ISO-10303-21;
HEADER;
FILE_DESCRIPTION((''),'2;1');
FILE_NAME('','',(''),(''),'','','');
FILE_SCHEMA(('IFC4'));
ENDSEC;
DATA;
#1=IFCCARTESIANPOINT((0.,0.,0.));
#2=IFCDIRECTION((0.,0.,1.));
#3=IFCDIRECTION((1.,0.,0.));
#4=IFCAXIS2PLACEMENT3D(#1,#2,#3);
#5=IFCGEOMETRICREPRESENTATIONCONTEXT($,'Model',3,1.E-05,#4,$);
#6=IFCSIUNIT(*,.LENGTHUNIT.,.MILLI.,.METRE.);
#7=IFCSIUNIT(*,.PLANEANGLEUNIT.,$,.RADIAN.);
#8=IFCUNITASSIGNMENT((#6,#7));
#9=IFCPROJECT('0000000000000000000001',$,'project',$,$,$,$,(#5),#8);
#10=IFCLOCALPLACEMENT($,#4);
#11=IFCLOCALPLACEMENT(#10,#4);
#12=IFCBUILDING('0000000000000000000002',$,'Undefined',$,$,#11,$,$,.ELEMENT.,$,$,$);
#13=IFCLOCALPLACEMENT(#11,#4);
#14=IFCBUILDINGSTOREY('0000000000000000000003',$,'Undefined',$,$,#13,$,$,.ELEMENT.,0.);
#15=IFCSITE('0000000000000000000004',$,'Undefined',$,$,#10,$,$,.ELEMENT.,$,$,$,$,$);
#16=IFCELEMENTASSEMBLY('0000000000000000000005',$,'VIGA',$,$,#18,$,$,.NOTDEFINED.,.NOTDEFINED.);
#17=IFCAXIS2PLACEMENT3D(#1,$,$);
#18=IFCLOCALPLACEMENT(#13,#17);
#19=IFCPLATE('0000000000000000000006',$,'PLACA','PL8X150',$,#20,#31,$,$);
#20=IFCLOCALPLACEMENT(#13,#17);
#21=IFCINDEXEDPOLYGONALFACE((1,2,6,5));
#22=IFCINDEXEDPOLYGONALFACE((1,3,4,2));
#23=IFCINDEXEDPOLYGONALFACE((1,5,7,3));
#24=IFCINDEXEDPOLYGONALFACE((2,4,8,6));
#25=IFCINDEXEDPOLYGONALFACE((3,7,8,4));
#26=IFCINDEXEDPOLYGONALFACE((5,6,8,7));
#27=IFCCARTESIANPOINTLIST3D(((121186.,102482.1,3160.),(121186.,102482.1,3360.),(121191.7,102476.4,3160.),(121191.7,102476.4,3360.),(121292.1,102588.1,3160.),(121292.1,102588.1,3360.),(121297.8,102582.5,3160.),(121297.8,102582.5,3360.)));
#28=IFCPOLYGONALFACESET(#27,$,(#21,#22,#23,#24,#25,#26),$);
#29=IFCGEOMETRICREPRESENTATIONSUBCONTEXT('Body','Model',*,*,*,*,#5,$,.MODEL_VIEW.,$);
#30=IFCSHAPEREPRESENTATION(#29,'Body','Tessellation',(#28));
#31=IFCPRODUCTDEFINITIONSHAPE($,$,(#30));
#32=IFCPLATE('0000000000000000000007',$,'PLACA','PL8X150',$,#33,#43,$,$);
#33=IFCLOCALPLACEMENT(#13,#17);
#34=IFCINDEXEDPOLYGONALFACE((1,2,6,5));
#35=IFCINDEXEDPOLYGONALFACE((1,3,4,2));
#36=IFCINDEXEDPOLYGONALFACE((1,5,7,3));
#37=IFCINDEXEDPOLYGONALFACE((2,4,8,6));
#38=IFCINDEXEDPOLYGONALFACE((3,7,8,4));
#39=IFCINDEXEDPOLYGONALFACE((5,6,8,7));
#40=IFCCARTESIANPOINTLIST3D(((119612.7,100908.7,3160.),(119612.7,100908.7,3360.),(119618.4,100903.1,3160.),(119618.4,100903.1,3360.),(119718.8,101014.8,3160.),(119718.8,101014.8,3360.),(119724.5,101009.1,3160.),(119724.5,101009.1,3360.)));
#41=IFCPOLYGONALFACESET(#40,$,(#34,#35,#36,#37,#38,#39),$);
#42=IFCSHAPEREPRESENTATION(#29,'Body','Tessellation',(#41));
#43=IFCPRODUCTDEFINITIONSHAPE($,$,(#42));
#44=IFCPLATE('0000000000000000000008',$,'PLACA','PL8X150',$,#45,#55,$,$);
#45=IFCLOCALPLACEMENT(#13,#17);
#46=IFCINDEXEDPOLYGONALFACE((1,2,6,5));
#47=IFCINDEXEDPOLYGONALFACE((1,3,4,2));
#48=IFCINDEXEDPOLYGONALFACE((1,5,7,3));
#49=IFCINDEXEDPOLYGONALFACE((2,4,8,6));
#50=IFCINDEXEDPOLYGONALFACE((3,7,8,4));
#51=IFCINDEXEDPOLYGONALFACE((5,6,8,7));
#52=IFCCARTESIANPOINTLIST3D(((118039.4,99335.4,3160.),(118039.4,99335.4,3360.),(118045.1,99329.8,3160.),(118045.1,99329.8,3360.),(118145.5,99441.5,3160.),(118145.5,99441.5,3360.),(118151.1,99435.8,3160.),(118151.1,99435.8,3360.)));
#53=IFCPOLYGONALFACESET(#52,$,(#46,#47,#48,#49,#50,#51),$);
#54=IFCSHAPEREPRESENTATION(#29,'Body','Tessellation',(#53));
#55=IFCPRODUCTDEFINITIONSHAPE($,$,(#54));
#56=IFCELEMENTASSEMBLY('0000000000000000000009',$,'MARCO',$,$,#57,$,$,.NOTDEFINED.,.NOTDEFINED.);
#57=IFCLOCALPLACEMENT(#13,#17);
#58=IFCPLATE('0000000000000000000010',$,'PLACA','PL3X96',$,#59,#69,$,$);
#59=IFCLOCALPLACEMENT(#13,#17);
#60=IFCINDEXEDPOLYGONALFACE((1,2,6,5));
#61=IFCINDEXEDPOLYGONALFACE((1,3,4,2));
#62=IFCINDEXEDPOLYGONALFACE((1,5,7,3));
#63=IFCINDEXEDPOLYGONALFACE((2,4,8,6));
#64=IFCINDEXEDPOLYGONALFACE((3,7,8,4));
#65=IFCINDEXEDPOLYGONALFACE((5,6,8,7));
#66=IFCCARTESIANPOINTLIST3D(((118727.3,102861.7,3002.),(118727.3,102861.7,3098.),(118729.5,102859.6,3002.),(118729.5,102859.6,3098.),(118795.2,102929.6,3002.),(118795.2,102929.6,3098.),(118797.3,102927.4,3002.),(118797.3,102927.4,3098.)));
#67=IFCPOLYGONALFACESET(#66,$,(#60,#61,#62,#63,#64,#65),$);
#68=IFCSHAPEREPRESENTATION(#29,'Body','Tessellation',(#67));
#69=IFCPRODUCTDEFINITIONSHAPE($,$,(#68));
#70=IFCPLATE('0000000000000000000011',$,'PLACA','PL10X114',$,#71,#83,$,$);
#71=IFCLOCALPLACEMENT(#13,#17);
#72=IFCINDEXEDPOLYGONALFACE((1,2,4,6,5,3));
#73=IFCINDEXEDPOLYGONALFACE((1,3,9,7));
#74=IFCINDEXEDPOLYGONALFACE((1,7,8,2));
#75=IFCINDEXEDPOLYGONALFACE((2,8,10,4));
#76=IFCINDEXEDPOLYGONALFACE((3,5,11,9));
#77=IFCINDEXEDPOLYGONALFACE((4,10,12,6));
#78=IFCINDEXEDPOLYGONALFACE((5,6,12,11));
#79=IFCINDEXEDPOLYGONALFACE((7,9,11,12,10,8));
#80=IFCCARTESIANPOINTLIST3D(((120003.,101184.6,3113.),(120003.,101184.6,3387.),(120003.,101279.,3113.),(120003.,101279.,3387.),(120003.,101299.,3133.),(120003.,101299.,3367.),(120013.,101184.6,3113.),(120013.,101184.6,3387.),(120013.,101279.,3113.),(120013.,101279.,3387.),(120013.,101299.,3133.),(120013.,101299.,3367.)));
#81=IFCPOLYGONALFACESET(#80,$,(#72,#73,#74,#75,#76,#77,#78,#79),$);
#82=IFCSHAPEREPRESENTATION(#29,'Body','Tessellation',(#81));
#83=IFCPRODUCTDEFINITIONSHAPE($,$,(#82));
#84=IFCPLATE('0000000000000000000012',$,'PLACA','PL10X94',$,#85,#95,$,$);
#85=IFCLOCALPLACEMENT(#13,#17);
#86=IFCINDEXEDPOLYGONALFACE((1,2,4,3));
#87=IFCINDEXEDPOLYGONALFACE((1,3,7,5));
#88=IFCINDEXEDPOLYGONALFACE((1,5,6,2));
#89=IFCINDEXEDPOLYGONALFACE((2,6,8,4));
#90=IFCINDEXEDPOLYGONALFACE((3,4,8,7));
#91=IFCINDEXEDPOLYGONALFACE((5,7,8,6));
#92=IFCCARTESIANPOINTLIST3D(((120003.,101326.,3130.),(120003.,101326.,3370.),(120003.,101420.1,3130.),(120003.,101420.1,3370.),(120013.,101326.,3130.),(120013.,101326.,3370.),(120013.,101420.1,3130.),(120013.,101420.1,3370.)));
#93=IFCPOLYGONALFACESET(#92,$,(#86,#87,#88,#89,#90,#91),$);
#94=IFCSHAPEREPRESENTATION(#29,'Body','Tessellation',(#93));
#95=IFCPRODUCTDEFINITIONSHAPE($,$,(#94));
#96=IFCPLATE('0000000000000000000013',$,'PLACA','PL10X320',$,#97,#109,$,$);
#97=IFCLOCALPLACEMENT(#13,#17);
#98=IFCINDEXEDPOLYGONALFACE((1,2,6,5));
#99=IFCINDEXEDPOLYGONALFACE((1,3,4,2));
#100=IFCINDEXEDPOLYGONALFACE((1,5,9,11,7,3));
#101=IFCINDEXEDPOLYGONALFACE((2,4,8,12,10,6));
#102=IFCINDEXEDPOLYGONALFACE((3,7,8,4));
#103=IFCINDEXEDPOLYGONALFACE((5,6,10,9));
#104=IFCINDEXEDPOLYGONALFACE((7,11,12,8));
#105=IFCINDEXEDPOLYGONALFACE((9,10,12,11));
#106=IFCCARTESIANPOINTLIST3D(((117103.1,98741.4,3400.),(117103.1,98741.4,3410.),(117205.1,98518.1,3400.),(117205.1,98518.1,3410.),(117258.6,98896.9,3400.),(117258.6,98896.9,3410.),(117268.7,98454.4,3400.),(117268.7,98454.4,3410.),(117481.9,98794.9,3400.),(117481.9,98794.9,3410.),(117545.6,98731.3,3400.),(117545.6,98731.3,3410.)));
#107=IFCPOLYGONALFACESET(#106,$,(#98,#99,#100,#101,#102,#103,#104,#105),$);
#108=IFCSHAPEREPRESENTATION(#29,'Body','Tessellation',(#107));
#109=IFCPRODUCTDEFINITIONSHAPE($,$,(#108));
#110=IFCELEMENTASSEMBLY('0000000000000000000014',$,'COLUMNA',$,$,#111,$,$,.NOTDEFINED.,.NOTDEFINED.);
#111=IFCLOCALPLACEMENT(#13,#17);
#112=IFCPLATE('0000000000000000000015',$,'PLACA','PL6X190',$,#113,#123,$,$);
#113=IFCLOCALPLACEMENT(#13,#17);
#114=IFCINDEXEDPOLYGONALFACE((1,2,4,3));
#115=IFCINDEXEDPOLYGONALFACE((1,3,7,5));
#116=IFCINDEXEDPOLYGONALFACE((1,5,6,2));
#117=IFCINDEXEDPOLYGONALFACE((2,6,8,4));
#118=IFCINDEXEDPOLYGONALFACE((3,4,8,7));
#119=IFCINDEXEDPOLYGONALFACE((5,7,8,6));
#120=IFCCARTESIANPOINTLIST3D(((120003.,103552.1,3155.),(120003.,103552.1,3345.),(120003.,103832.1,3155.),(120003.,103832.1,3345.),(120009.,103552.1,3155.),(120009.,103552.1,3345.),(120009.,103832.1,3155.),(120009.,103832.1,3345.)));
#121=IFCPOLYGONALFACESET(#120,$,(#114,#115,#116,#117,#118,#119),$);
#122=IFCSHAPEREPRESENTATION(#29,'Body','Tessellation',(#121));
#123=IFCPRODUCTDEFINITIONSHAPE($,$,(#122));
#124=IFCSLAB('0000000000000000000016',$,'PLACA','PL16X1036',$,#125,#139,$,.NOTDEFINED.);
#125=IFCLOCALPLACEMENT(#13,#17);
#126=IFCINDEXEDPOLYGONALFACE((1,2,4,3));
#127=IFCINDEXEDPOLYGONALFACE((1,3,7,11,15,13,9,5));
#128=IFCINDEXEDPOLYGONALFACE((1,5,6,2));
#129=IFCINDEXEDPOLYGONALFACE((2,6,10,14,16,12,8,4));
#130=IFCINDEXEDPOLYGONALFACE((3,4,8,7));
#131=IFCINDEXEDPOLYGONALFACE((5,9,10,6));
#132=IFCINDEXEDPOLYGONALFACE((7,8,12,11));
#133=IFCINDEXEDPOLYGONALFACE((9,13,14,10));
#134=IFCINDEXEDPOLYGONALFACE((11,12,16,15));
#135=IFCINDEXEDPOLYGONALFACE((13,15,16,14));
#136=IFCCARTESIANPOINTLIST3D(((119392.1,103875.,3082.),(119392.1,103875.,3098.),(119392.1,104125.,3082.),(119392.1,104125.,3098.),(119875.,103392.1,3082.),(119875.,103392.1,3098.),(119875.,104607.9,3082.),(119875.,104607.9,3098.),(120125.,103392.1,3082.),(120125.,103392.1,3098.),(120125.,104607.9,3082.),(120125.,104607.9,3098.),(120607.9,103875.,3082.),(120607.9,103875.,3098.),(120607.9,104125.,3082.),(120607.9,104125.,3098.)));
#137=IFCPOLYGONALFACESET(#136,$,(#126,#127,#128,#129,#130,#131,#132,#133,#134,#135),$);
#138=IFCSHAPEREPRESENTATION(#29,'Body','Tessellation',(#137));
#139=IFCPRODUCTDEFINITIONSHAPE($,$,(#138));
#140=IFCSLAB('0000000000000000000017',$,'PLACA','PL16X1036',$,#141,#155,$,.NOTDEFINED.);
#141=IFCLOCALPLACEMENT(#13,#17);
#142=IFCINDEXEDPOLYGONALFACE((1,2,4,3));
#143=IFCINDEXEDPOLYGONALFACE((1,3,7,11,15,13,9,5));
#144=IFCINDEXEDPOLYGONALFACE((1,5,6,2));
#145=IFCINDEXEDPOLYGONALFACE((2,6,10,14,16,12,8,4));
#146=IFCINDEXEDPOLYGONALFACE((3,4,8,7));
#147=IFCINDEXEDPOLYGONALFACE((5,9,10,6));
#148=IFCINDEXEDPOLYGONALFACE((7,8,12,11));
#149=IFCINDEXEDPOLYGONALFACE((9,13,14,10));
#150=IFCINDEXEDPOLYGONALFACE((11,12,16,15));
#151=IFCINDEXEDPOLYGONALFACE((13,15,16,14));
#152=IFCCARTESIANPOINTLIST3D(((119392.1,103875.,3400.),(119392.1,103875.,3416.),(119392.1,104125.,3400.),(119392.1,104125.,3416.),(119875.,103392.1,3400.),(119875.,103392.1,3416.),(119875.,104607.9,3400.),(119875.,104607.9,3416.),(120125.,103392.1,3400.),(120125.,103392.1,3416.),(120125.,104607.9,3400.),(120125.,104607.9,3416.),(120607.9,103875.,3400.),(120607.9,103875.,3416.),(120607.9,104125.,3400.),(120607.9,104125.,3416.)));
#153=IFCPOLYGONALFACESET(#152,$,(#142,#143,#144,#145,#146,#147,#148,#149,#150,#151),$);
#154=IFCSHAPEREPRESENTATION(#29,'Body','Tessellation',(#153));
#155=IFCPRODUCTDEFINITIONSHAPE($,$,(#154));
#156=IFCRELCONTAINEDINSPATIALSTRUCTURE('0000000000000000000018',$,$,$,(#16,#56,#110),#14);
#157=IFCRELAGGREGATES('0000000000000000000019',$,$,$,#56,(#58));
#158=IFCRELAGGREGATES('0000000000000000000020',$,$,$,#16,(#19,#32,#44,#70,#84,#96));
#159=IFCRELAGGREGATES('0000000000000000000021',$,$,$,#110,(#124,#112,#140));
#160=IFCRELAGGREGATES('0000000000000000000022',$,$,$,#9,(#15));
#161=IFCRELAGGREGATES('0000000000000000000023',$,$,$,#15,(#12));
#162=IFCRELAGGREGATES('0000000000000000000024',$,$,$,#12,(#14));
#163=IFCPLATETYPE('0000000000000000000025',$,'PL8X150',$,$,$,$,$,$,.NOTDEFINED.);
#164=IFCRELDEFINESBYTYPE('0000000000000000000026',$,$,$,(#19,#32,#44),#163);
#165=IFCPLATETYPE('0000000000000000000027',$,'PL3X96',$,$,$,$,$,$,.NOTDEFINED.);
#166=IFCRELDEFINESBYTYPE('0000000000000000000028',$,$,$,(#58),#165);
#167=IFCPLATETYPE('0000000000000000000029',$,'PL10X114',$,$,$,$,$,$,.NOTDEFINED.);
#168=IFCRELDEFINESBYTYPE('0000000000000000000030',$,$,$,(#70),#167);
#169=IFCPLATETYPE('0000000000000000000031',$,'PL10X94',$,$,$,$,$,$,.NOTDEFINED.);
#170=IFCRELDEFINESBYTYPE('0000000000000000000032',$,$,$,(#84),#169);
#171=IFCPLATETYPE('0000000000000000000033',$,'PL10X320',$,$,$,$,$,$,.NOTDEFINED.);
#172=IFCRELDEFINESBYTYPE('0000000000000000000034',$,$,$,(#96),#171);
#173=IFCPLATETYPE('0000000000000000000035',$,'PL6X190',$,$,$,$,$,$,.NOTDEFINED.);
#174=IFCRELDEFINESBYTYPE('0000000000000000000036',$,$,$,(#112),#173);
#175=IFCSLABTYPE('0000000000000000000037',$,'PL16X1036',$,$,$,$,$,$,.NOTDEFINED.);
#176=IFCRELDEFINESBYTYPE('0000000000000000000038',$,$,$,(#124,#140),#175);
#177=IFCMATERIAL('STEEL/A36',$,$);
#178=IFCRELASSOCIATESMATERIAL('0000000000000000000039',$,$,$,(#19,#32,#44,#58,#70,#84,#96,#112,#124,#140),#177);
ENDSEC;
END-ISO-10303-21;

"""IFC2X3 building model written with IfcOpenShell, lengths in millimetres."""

from ifc_helpers import new_model, si_unit, frame, origin_with_axes, place, context, subcontext, project, spatial, polyline, outline, extrude, material, type_object, element, aggregate, save


model = new_model("IFC2X3")

# Units and contexts
model_context = context("Model", 3, precision=1e-05, world=origin_with_axes())
body_context = subcontext(model_context, "Body", "Model", "MODEL_VIEW")
ifc_project = project(units=[si_unit("LENGTHUNIT", "METRE", prefix="MILLI"), si_unit("PLANEANGLEUNIT", "RADIAN")], contexts=[model_context])

# Site, building, storey
site_placement = place(None, origin_with_axes())
site = spatial("IfcSite", under=ifc_project, at=site_placement, Name="Undefined", CompositionType="ELEMENT")
building_placement = place(site_placement, origin_with_axes())
building = spatial("IfcBuilding", under=site, at=building_placement, Name="Undefined", CompositionType="ELEMENT")
storey_placement = place(building_placement, origin_with_axes())
storey = spatial("IfcBuildingStorey", under=building, at=storey_placement, Name="Undefined", CompositionType="ELEMENT", Elevation=0.0)

# Shared definitions
ifc_material_1 = material(Name="STEEL/A36")

# Element assembly
assembly_1_placement = place(storey_placement, origin_with_axes())
assembly_1 = element("IfcElementAssembly", 1, at=assembly_1_placement, inside=storey, Name="VIGA", AssemblyPlace="NOTDEFINED", PredefinedType="NOTDEFINED")

# Plates
plate_type_1 = type_object("IfcPlateType", Name="PL8X150", PredefinedType="NOTDEFINED")
plate_1_placement = place(assembly_1_placement, frame((121188.9, 102479.2, 3360.0), z_axis=(-0.707107, 0.707106, 0.0), x_axis=(0.707106, 0.707107, 0.0)))
plate_1 = element("IfcPlate", 2, at=plate_1_placement, type_object=plate_type_1, material=ifc_material_1, Name="PLACA", Description="PL8X150", context=body_context, shape_type="SweptSolid", body=[
    extrude(outline(polyline([(0.0, 0.0), (150.0, 0.0), (150.0, 200.0), (0.0, 200.0), (0.0, 0.0)])), frame((0.0, 0.0, -4.0), z_axis=(0.0, 0.0, 1.0), x_axis=(1.0, 0.0, 0.0)), (0.0, 0.0, 1.0), 8.0),
])
plate_2_placement = place(assembly_1_placement, frame((119615.6, 100905.9, 3360.0), z_axis=(-0.707107, 0.707106, 0.0), x_axis=(0.707106, 0.707107, 0.0)))
plate_2 = element("IfcPlate", 3, at=plate_2_placement, type_object=plate_type_1, material=ifc_material_1, Name="PLACA", Description="PL8X150", context=body_context, shape_type="SweptSolid", body=[
    extrude(outline(polyline([(0.0, 0.0), (150.0, 0.0), (150.0, 200.0), (0.0, 200.0), (0.0, 0.0)])), frame((0.0, 0.0, -4.0), z_axis=(0.0, 0.0, 1.0), x_axis=(1.0, 0.0, 0.0)), (0.0, 0.0, 1.0), 8.0),
])
plate_3_placement = place(assembly_1_placement, frame((118042.2, 99332.6, 3360.0), z_axis=(-0.707107, 0.707106, 0.0), x_axis=(0.707106, 0.707107, 0.0)))
plate_3 = element("IfcPlate", 4, at=plate_3_placement, type_object=plate_type_1, material=ifc_material_1, Name="PLACA", Description="PL8X150", context=body_context, shape_type="SweptSolid", body=[
    extrude(outline(polyline([(0.0, 0.0), (150.0, 0.0), (150.0, 200.0), (0.0, 200.0), (0.0, 0.0)])), frame((0.0, 0.0, -4.0), z_axis=(0.0, 0.0, 1.0), x_axis=(1.0, 0.0, 0.0)), (0.0, 0.0, 1.0), 8.0),
])

# Element assembly, plate
assembly_2_placement = place(storey_placement, origin_with_axes())
assembly_2 = element("IfcElementAssembly", 5, at=assembly_2_placement, inside=storey, Name="MARCO", AssemblyPlace="NOTDEFINED", PredefinedType="NOTDEFINED")
plate_type_2 = type_object("IfcPlateType", Name="PL3X96", PredefinedType="NOTDEFINED")
plate_4_placement = place(assembly_2_placement, frame((118728.4, 102860.6, 3098.0), z_axis=(-0.707107, 0.707107, 0.0), x_axis=(0.707107, 0.707107, 0.0)))
plate_4 = element("IfcPlate", 6, at=plate_4_placement, type_object=plate_type_2, material=ifc_material_1, Name="PLACA", Description="PL3X96", context=body_context, shape_type="SweptSolid", body=[
    extrude(outline(polyline([(0.0, 0.0), (96.0, 0.0), (96.0, 96.0), (0.0, 96.0), (0.0, 0.0)])), frame((0.0, 0.0, -1.5), z_axis=(0.0, 0.0, 1.0), x_axis=(1.0, 0.0, 0.0)), (0.0, 0.0, 1.0), 3.0),
])
aggregate(assembly_2, [plate_4])

# Plates
plate_type_3 = type_object("IfcPlateType", Name="PL10X114", PredefinedType="NOTDEFINED")
plate_5_placement = place(assembly_1_placement, frame((120008.0, 101299.0, 3113.0), z_axis=(-1.0, 0.0, 0.0), x_axis=(0.0, -1.0, 0.0)))
plate_5 = element("IfcPlate", 7, at=plate_5_placement, type_object=plate_type_3, material=ifc_material_1, Name="PLACA", Description="PL10X114", context=body_context, shape_type="SweptSolid", body=[
    extrude(outline(polyline([(0.0, 20.0), (20.0, 0.0), (114.5, 0.0), (114.5, 274.0), (20.0, 274.0), (0.0, 254.0), (0.0, 20.0)])), frame((0.0, 0.0, -5.0), z_axis=(0.0, 0.0, 1.0), x_axis=(1.0, 0.0, 0.0)), (0.0, 0.0, 1.0), 10.0),
])
plate_type_4 = type_object("IfcPlateType", Name="PL10X94", PredefinedType="NOTDEFINED")
plate_6_placement = place(assembly_1_placement, frame((120008.0, 101326.0, 3370.0), z_axis=(1.0, 0.0, 0.0), x_axis=(0.0, 0.0, -1.0)))
plate_6 = element("IfcPlate", 8, at=plate_6_placement, type_object=plate_type_4, material=ifc_material_1, Name="PLACA", Description="PL10X94", context=body_context, shape_type="SweptSolid", body=[
    extrude(outline(polyline([(0.0, 0.0), (240.0, 0.0), (240.0, 94.1), (0.0, 94.1), (0.0, 0.0)])), frame((0.0, 0.0, -5.0), z_axis=(0.0, 0.0, 1.0), x_axis=(1.0, 0.0, 0.0)), (0.0, 0.0, 1.0), 10.0),
])
plate_type_5 = type_object("IfcPlateType", Name="PL10X320", PredefinedType="NOTDEFINED")
plate_7_placement = place(assembly_1_placement, frame((117545.6, 98731.3, 3405.0), z_axis=(0.0, 0.0, -1.0), x_axis=(-0.707107, -0.707107, 0.0)))
plate_7 = element("IfcPlate", 9, at=plate_7_placement, type_object=plate_type_5, material=ifc_material_1, Name="PLACA", Description="PL10X320", context=body_context, shape_type="SweptSolid", body=[
    extrude(outline(polyline([(0.0, 0.0), (391.5, 0.0), (391.5, 90.0), (305.7, 320.0), (85.7, 320.0), (0.0, 90.0), (0.0, 0.0)])), frame((0.0, 0.0, -5.0), z_axis=(0.0, 0.0, 1.0), x_axis=(1.0, 0.0, 0.0)), (0.0, 0.0, 1.0), 10.0),
])
aggregate(assembly_1, [plate_1, plate_2, plate_3, plate_5, plate_6, plate_7])

# Element assembly, plate, slabs
assembly_3_placement = place(storey_placement, origin_with_axes())
assembly_3 = element("IfcElementAssembly", 10, at=assembly_3_placement, inside=storey, Name="COLUMNA", AssemblyPlace="NOTDEFINED", PredefinedType="NOTDEFINED")
plate_type_6 = type_object("IfcPlateType", Name="PL6X190", PredefinedType="NOTDEFINED")
plate_8_placement = place(assembly_3_placement, frame((120006.0, 103552.1, 3250.0), z_axis=(1.0, 0.0, 0.0), x_axis=(0.0, 1.0, 0.0)))
plate_8 = element("IfcPlate", 11, at=plate_8_placement, type_object=plate_type_6, material=ifc_material_1, Name="PLACA", Description="PL6X190", context=body_context, shape_type="SweptSolid", body=[
    extrude(outline(polyline([(0.0, -95.0), (0.0, 95.0), (280.0, 95.0), (280.0, -95.0), (0.0, -95.0)])), frame((0.0, 0.0, -3.0), z_axis=(0.0, 0.0, 1.0), x_axis=(1.0, 0.0, 0.0)), (0.0, 0.0, 1.0), 6.0),
])
slab_type = type_object("IfcSlabType", Name="PL16X1036", PredefinedType="NOTDEFINED")
slab_1_placement = place(assembly_3_placement, frame((120125.0, 103392.1, 3090.0), z_axis=(0.0, 0.0, 1.0), x_axis=(0.707107, 0.707107, 0.0)))
slab_1 = element("IfcSlab", 12, at=slab_1_placement, type_object=slab_type, material=ifc_material_1, Name="PLACA", Description="PL16X1036", PredefinedType="NOTDEFINED", context=body_context, shape_type="SweptSolid", body=[
    extrude(outline(polyline([(0.0, 0.0), (682.9, 0.0), (859.7, 176.8), (859.7, 859.7), (682.9, 1036.5), (0.0, 1036.5), (-176.8, 859.7), (-176.8, 176.8), (0.0, 0.0)])), frame((0.0, 0.0, -8.0), z_axis=(0.0, 0.0, 1.0), x_axis=(1.0, 0.0, 0.0)), (0.0, 0.0, 1.0), 16.0),
])
slab_2_placement = place(assembly_3_placement, frame((120125.0, 103392.1, 3408.0), z_axis=(0.0, 0.0, 1.0), x_axis=(0.707107, 0.707107, 0.0)))
slab_2 = element("IfcSlab", 13, at=slab_2_placement, type_object=slab_type, material=ifc_material_1, Name="PLACA", Description="PL16X1036", PredefinedType="NOTDEFINED", context=body_context, shape_type="SweptSolid", body=[
    extrude(outline(polyline([(0.0, 0.0), (682.9, 0.0), (859.7, 176.8), (859.7, 859.7), (682.9, 1036.5), (0.0, 1036.5), (-176.8, 859.7), (-176.8, 176.8), (0.0, 0.0)])), frame((0.0, 0.0, -8.0), z_axis=(0.0, 0.0, 1.0), x_axis=(1.0, 0.0, 0.0)), (0.0, 0.0, 1.0), 16.0),
])

aggregate(assembly_3, [slab_1, plate_8, slab_2])

save(model, "model.ifc")
